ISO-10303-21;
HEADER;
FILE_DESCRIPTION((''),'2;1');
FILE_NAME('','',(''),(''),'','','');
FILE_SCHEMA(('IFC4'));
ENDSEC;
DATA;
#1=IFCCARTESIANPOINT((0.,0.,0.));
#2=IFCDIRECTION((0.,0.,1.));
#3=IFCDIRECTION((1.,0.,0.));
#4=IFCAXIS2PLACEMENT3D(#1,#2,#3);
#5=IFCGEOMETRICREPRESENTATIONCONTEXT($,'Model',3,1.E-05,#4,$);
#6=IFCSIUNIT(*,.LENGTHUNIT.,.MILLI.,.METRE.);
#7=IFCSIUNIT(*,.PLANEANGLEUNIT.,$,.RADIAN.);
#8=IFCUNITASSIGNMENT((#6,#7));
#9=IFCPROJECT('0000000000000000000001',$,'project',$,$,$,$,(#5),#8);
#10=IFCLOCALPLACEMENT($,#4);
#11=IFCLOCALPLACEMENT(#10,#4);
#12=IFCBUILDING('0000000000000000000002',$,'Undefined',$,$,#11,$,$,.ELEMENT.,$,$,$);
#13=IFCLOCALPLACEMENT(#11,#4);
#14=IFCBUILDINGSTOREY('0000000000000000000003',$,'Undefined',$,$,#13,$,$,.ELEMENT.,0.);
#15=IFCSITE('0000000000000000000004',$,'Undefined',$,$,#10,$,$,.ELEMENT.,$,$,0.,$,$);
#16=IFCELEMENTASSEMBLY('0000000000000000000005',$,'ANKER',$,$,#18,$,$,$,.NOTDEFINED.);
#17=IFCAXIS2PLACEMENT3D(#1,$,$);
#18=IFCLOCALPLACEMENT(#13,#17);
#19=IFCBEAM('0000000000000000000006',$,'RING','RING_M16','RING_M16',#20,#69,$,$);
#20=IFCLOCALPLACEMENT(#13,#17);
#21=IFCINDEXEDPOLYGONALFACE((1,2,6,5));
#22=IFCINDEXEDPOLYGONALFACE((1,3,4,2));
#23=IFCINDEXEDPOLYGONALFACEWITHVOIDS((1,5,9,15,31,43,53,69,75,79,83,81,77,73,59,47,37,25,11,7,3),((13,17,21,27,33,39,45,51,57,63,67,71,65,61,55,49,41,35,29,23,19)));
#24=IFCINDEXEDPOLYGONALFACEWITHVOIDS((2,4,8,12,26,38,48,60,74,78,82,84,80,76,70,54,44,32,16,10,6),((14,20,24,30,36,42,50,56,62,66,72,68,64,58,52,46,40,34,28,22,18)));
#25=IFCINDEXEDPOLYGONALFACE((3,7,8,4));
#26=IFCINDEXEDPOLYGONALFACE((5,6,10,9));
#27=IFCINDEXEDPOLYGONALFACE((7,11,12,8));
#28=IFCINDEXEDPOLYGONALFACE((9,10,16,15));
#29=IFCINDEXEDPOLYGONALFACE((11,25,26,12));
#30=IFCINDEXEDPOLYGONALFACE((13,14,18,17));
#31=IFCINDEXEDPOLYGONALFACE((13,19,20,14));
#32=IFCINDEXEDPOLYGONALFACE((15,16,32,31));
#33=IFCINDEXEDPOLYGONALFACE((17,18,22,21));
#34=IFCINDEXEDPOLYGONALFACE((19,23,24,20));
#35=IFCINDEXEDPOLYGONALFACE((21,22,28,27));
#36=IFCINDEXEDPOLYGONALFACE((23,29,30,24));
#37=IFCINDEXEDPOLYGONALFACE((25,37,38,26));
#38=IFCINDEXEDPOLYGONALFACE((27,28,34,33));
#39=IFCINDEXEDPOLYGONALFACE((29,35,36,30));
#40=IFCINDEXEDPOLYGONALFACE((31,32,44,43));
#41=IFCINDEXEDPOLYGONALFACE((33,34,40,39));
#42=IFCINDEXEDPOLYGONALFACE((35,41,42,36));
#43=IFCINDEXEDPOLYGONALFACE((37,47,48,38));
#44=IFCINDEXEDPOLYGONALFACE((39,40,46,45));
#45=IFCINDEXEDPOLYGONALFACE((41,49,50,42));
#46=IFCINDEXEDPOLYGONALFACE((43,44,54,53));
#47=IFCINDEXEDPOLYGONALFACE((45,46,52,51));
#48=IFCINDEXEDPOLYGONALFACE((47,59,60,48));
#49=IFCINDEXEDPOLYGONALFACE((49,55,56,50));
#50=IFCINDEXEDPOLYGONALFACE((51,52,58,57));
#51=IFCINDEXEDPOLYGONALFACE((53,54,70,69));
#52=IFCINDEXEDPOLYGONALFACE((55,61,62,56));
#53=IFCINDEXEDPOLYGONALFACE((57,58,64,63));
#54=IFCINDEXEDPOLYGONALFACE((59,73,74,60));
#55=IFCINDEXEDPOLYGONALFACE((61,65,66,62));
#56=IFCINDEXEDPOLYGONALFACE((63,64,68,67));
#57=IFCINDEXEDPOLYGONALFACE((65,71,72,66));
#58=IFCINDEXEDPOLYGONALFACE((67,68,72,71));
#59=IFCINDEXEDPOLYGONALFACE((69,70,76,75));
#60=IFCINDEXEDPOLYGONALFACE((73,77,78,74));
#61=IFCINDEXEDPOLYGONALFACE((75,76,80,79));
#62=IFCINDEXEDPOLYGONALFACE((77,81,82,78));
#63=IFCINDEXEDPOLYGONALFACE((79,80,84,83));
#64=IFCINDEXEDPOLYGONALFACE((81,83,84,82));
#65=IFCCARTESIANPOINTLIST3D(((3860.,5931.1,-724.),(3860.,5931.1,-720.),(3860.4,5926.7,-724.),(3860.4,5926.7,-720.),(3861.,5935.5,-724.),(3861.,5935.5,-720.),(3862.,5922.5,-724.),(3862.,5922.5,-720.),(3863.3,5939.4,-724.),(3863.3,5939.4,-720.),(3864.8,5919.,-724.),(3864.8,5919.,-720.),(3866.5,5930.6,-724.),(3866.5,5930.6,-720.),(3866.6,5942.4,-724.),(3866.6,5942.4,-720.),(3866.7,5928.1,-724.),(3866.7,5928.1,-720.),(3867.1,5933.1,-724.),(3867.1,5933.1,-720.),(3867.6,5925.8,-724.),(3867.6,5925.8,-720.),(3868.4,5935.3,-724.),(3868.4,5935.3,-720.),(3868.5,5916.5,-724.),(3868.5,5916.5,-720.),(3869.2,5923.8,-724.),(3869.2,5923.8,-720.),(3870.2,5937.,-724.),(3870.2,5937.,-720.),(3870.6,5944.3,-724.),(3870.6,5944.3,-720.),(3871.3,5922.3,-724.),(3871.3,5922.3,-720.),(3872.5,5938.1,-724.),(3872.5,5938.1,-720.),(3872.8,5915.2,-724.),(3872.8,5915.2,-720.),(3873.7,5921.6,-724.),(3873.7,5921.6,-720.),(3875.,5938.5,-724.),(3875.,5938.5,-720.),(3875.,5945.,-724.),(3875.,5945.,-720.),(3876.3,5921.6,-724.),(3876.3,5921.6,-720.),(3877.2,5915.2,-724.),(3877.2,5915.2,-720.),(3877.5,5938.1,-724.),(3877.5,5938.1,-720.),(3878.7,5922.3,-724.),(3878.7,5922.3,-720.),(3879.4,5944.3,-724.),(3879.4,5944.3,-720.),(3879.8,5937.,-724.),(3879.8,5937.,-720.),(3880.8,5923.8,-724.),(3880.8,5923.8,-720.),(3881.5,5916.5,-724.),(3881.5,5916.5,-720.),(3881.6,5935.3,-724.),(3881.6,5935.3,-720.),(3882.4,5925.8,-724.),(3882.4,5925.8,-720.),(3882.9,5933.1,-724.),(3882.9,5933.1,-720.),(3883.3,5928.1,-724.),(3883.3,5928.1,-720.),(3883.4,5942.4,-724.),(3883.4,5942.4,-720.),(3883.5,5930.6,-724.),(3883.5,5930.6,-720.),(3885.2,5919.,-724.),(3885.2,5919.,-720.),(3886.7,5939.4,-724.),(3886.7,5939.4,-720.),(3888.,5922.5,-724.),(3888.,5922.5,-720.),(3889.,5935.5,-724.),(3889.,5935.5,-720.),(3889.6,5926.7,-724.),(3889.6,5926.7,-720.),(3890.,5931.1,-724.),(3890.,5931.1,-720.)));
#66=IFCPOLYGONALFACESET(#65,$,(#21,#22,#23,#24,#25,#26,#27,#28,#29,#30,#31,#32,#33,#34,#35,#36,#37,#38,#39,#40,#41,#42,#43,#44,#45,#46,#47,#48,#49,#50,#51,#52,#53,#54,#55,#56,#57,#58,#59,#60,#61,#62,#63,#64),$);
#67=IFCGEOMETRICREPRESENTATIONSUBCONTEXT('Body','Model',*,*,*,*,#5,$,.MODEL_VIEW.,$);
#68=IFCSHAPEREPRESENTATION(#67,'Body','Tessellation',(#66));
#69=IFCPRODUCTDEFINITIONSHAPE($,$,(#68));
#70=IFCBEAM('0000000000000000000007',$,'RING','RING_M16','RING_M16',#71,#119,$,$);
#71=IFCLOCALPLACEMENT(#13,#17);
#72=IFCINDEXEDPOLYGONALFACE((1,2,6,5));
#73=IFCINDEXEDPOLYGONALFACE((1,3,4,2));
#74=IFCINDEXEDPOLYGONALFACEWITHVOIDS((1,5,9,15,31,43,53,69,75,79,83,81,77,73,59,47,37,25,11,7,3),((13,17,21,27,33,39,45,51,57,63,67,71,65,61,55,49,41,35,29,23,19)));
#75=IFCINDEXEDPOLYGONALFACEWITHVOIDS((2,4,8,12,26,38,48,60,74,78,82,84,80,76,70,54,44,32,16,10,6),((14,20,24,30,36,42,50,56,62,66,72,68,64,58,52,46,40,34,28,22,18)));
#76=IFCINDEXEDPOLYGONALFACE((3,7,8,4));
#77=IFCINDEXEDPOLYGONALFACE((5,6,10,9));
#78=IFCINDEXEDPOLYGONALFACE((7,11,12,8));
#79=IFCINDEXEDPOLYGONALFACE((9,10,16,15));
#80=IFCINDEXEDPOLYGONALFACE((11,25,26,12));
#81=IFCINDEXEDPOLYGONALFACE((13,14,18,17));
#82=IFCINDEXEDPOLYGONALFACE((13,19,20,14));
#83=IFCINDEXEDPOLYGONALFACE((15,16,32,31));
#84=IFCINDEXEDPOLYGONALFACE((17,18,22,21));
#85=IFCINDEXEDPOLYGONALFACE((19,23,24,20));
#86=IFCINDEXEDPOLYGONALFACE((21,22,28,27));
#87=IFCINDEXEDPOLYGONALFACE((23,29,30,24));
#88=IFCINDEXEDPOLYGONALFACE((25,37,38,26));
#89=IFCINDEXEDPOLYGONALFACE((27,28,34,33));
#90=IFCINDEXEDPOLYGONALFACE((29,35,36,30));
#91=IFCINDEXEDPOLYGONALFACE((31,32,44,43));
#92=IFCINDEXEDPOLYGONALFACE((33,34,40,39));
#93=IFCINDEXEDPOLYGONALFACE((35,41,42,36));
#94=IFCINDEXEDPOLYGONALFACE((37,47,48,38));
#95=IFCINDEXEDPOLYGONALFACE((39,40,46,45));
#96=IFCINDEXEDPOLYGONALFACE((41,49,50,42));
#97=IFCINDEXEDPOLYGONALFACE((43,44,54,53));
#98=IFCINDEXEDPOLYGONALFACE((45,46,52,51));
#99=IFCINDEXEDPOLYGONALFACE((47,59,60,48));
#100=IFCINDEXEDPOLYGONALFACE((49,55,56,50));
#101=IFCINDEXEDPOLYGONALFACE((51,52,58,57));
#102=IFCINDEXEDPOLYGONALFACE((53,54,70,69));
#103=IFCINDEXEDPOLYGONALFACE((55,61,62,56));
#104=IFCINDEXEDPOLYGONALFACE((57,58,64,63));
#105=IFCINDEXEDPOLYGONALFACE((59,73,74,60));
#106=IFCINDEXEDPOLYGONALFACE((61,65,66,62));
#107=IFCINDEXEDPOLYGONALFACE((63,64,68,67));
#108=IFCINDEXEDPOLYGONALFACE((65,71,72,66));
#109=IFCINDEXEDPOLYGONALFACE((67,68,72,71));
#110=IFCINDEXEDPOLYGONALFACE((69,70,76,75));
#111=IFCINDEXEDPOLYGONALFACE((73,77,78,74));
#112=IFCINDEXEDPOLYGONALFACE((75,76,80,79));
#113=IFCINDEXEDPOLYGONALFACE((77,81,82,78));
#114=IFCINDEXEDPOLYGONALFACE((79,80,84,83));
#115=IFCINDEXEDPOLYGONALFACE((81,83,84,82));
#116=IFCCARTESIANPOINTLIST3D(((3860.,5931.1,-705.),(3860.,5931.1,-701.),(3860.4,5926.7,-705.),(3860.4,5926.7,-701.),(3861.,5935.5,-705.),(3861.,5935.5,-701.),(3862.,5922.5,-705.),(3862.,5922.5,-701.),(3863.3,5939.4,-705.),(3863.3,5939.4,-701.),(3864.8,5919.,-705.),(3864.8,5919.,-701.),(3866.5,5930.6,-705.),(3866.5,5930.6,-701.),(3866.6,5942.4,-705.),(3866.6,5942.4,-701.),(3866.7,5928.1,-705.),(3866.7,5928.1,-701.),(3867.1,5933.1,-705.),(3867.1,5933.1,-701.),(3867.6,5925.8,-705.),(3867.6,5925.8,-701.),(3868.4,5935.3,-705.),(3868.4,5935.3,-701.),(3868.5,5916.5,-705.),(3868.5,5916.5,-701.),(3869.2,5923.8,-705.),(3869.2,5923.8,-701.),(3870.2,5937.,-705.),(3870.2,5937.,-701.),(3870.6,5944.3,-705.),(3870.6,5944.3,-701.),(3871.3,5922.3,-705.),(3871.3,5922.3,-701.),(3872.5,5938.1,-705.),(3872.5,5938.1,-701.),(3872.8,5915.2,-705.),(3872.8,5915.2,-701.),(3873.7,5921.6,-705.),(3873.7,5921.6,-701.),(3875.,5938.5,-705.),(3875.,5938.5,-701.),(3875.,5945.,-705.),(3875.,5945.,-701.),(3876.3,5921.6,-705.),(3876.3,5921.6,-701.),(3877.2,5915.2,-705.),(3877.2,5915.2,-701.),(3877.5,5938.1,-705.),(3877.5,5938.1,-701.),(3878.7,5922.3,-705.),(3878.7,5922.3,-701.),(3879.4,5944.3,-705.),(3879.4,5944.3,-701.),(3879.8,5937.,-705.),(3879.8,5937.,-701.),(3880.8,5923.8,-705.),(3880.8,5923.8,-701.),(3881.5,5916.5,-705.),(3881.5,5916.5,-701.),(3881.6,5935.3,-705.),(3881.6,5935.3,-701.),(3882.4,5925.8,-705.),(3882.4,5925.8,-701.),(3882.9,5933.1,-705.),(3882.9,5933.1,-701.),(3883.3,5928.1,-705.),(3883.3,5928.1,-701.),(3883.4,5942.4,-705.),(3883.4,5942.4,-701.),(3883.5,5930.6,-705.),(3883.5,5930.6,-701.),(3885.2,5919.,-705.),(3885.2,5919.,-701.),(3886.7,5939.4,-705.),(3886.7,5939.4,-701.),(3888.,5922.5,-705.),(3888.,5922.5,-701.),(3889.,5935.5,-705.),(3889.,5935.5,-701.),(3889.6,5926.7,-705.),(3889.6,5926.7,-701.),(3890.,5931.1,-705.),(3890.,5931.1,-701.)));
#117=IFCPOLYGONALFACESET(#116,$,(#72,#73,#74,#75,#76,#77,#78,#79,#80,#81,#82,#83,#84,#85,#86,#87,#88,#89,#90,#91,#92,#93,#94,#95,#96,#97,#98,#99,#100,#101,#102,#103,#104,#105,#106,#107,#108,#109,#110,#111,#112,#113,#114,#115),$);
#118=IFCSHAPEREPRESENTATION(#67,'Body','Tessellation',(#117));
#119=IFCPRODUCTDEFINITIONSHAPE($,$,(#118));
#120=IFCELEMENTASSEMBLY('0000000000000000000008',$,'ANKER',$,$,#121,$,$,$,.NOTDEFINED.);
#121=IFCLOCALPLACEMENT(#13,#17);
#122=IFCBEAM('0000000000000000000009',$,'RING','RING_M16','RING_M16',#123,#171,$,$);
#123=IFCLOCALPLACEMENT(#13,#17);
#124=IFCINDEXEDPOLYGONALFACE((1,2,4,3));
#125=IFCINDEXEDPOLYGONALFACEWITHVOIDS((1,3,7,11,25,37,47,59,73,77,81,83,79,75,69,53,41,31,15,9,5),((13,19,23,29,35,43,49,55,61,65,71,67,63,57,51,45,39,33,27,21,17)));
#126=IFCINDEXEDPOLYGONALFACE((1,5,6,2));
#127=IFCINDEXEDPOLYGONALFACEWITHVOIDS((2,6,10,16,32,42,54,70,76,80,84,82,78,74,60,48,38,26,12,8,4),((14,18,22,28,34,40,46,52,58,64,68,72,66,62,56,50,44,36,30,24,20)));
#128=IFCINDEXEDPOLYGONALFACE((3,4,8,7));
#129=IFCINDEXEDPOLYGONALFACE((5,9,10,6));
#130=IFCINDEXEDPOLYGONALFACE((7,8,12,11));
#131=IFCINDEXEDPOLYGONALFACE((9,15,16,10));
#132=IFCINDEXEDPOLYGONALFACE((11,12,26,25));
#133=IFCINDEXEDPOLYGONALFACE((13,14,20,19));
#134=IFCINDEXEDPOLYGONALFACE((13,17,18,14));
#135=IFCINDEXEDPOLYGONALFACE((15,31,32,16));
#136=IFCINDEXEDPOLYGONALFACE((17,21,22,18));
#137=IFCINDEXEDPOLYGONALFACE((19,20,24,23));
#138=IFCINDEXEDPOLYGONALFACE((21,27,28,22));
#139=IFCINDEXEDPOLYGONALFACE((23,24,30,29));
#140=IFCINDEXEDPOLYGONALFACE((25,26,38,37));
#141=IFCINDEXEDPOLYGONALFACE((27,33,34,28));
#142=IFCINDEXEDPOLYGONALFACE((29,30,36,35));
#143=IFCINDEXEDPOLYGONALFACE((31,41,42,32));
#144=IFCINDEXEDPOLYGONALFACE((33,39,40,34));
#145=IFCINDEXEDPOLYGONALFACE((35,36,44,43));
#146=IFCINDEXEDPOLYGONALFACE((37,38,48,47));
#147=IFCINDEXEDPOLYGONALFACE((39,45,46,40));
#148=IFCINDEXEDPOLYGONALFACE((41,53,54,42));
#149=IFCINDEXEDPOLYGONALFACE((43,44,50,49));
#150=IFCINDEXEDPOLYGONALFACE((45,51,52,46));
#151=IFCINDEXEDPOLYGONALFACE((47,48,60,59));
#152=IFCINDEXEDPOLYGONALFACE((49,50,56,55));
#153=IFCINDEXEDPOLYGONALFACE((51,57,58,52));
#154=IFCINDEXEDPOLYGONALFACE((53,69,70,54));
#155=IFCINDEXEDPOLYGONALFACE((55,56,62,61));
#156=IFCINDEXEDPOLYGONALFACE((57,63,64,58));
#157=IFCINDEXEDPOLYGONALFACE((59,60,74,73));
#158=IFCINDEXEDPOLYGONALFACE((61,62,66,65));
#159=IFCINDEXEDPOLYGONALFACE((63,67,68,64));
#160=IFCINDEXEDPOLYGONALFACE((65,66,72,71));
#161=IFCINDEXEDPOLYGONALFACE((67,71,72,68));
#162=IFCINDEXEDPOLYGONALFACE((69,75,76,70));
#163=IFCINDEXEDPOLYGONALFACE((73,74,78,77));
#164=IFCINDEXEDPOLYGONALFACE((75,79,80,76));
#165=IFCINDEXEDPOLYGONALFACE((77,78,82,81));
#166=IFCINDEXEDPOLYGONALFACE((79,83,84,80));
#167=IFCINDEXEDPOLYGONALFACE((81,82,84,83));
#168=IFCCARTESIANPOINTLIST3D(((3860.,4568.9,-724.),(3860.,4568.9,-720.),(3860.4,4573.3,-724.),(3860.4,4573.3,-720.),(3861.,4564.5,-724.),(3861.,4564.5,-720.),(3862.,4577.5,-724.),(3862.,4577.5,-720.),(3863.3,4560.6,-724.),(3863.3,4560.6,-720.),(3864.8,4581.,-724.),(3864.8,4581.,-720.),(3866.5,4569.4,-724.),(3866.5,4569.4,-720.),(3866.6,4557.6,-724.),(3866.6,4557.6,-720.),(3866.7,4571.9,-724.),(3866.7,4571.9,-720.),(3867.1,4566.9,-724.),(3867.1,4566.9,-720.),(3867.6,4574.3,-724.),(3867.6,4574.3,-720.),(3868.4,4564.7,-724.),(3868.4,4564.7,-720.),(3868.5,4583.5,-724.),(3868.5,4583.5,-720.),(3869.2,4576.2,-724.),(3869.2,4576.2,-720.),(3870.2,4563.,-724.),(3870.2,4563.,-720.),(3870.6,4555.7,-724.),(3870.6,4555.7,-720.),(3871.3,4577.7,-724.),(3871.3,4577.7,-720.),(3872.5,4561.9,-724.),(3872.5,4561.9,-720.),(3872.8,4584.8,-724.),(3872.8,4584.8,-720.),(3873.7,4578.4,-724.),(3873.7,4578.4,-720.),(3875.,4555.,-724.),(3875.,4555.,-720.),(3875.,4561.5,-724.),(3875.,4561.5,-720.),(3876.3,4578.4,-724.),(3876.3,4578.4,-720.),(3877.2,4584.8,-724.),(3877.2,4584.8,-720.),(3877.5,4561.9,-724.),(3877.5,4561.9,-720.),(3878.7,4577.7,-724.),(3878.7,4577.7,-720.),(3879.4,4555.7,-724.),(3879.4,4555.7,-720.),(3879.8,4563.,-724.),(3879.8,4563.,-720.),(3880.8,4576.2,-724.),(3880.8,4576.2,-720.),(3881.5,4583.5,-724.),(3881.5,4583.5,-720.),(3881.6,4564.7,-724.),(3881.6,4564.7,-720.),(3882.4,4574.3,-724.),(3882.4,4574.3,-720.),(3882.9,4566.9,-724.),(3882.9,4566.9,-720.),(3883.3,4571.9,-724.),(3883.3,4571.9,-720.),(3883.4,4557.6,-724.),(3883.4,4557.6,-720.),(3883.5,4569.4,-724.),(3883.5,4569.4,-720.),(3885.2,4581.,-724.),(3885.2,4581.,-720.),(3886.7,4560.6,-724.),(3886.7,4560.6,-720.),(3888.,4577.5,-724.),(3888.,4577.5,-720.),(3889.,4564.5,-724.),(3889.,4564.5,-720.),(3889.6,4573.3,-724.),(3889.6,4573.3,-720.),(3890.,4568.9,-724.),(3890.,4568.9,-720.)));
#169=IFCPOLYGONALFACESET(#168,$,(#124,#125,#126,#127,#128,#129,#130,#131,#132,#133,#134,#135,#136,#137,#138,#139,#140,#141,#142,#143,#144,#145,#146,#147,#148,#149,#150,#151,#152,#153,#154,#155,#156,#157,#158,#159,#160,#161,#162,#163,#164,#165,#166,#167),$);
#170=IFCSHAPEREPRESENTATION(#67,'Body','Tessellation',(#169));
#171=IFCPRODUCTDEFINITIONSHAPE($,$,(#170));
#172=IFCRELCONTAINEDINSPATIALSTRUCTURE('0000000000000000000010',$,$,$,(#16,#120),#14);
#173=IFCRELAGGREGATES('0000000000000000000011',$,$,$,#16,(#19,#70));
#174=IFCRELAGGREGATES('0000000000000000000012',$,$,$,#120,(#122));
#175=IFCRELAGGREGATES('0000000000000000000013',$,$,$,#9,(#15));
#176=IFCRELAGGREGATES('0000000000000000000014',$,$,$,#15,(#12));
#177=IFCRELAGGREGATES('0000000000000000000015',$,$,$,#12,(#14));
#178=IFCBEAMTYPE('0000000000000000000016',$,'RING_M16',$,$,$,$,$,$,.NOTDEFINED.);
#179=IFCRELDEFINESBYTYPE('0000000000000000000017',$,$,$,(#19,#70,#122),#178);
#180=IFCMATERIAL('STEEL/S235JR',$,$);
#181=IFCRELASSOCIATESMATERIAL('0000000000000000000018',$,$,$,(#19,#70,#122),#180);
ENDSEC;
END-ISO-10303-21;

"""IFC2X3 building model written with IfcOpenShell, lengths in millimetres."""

from ifc_helpers import new_model, si_unit, frame, origin_with_axes, origin_2d_with_axis, place, context, subcontext, project, spatial, hollow_circle, extrude, material, type_object, element, aggregate, save


model = new_model("IFC2X3")

# Units and contexts
model_context = context("Model", 3, precision=1e-05, world=origin_with_axes())
body_context = subcontext(model_context, "Body", "Model", "MODEL_VIEW")
ifc_project = project(units=[si_unit("LENGTHUNIT", "METRE", prefix="MILLI"), si_unit("PLANEANGLEUNIT", "RADIAN")], contexts=[model_context])

# Site, building, storey
site_placement = place(None, origin_with_axes())
site = spatial("IfcSite", under=ifc_project, at=site_placement, Name="Undefined", CompositionType="ELEMENT", RefElevation=0.0)
building_placement = place(site_placement, origin_with_axes())
building = spatial("IfcBuilding", under=site, at=building_placement, Name="Undefined", CompositionType="ELEMENT")
storey_placement = place(building_placement, origin_with_axes())
storey = spatial("IfcBuildingStorey", under=building, at=storey_placement, Name="Undefined", CompositionType="ELEMENT", Elevation=0.0)

# Shared definitions
ifc_material = material(Name="STEEL/S235JR")

# Element assemblies, beams
beam_type_1 = type_object("IfcBeamType", Name="RING_M16", PredefinedType="NOTDEFINED")
assembly_1_placement = place(storey_placement, frame((3875.0, 5930.0, -655.0), z_axis=(-1.0, 0.0, 0.0), x_axis=(0.0, 0.0, -1.0)))
assembly_1 = element("IfcElementAssembly", 1, at=assembly_1_placement, inside=storey, Name="ANKER", PredefinedType="NOTDEFINED")
beam_1_placement = place(storey_placement, frame((3875.0, 5930.0, -720.0), z_axis=(-1.0, 0.0, 0.0), x_axis=(0.0, 0.0, -1.0)))
beam_1 = element("IfcBeam", 2, at=beam_1_placement, type_object=beam_type_1, material=ifc_material, Name="RING", Description="RING_M16", ObjectType="RING_M16", context=body_context, shape_type="SweptSolid", body=[
    extrude(hollow_circle(Radius=15.0, WallThickness=6.5, at=origin_2d_with_axis()), frame((4.0, 0.0, 0.0), z_axis=(-1.0, 0.0, 0.0), x_axis=(0.0, -1.0, 0.0)), (0.0, 0.0, 1.0), 4.0),
])
beam_2_placement = place(storey_placement, frame((3875.0, 5930.0, -701.0), z_axis=(-1.0, 0.0, 0.0), x_axis=(0.0, 0.0, -1.0)))
beam_2 = element("IfcBeam", 3, at=beam_2_placement, type_object=beam_type_1, material=ifc_material, Name="RING", Description="RING_M16", ObjectType="RING_M16", context=body_context, shape_type="SweptSolid", body=[
    extrude(hollow_circle(Radius=15.0, WallThickness=6.5, at=origin_2d_with_axis()), frame((4.0, 0.0, 0.0), z_axis=(-1.0, 0.0, 0.0), x_axis=(0.0, -1.0, 0.0)), (0.0, 0.0, 1.0), 4.0),
])
aggregate(assembly_1, [beam_1, beam_2])
assembly_2_placement = place(storey_placement, frame((3875.0, 4570.0, -655.0), z_axis=(1.0, 0.0, 0.0), x_axis=(0.0, 0.0, -1.0)))
assembly_2 = element("IfcElementAssembly", 4, at=assembly_2_placement, inside=storey, Name="ANKER", PredefinedType="NOTDEFINED")
beam_3_placement = place(storey_placement, frame((3875.0, 4570.0, -720.0), z_axis=(1.0, 0.0, 0.0), x_axis=(0.0, 0.0, -1.0)))
beam_3 = element("IfcBeam", 5, at=beam_3_placement, type_object=beam_type_1, material=ifc_material, Name="RING", Description="RING_M16", ObjectType="RING_M16", context=body_context, shape_type="SweptSolid", body=[
    extrude(hollow_circle(Radius=15.0, WallThickness=6.5, at=origin_2d_with_axis()), frame((4.0, 0.0, 0.0), z_axis=(-1.0, 0.0, 0.0), x_axis=(0.0, -1.0, 0.0)), (0.0, 0.0, 1.0), 4.0),
])
aggregate(assembly_2, [beam_3])

save(model, "model.ifc")
